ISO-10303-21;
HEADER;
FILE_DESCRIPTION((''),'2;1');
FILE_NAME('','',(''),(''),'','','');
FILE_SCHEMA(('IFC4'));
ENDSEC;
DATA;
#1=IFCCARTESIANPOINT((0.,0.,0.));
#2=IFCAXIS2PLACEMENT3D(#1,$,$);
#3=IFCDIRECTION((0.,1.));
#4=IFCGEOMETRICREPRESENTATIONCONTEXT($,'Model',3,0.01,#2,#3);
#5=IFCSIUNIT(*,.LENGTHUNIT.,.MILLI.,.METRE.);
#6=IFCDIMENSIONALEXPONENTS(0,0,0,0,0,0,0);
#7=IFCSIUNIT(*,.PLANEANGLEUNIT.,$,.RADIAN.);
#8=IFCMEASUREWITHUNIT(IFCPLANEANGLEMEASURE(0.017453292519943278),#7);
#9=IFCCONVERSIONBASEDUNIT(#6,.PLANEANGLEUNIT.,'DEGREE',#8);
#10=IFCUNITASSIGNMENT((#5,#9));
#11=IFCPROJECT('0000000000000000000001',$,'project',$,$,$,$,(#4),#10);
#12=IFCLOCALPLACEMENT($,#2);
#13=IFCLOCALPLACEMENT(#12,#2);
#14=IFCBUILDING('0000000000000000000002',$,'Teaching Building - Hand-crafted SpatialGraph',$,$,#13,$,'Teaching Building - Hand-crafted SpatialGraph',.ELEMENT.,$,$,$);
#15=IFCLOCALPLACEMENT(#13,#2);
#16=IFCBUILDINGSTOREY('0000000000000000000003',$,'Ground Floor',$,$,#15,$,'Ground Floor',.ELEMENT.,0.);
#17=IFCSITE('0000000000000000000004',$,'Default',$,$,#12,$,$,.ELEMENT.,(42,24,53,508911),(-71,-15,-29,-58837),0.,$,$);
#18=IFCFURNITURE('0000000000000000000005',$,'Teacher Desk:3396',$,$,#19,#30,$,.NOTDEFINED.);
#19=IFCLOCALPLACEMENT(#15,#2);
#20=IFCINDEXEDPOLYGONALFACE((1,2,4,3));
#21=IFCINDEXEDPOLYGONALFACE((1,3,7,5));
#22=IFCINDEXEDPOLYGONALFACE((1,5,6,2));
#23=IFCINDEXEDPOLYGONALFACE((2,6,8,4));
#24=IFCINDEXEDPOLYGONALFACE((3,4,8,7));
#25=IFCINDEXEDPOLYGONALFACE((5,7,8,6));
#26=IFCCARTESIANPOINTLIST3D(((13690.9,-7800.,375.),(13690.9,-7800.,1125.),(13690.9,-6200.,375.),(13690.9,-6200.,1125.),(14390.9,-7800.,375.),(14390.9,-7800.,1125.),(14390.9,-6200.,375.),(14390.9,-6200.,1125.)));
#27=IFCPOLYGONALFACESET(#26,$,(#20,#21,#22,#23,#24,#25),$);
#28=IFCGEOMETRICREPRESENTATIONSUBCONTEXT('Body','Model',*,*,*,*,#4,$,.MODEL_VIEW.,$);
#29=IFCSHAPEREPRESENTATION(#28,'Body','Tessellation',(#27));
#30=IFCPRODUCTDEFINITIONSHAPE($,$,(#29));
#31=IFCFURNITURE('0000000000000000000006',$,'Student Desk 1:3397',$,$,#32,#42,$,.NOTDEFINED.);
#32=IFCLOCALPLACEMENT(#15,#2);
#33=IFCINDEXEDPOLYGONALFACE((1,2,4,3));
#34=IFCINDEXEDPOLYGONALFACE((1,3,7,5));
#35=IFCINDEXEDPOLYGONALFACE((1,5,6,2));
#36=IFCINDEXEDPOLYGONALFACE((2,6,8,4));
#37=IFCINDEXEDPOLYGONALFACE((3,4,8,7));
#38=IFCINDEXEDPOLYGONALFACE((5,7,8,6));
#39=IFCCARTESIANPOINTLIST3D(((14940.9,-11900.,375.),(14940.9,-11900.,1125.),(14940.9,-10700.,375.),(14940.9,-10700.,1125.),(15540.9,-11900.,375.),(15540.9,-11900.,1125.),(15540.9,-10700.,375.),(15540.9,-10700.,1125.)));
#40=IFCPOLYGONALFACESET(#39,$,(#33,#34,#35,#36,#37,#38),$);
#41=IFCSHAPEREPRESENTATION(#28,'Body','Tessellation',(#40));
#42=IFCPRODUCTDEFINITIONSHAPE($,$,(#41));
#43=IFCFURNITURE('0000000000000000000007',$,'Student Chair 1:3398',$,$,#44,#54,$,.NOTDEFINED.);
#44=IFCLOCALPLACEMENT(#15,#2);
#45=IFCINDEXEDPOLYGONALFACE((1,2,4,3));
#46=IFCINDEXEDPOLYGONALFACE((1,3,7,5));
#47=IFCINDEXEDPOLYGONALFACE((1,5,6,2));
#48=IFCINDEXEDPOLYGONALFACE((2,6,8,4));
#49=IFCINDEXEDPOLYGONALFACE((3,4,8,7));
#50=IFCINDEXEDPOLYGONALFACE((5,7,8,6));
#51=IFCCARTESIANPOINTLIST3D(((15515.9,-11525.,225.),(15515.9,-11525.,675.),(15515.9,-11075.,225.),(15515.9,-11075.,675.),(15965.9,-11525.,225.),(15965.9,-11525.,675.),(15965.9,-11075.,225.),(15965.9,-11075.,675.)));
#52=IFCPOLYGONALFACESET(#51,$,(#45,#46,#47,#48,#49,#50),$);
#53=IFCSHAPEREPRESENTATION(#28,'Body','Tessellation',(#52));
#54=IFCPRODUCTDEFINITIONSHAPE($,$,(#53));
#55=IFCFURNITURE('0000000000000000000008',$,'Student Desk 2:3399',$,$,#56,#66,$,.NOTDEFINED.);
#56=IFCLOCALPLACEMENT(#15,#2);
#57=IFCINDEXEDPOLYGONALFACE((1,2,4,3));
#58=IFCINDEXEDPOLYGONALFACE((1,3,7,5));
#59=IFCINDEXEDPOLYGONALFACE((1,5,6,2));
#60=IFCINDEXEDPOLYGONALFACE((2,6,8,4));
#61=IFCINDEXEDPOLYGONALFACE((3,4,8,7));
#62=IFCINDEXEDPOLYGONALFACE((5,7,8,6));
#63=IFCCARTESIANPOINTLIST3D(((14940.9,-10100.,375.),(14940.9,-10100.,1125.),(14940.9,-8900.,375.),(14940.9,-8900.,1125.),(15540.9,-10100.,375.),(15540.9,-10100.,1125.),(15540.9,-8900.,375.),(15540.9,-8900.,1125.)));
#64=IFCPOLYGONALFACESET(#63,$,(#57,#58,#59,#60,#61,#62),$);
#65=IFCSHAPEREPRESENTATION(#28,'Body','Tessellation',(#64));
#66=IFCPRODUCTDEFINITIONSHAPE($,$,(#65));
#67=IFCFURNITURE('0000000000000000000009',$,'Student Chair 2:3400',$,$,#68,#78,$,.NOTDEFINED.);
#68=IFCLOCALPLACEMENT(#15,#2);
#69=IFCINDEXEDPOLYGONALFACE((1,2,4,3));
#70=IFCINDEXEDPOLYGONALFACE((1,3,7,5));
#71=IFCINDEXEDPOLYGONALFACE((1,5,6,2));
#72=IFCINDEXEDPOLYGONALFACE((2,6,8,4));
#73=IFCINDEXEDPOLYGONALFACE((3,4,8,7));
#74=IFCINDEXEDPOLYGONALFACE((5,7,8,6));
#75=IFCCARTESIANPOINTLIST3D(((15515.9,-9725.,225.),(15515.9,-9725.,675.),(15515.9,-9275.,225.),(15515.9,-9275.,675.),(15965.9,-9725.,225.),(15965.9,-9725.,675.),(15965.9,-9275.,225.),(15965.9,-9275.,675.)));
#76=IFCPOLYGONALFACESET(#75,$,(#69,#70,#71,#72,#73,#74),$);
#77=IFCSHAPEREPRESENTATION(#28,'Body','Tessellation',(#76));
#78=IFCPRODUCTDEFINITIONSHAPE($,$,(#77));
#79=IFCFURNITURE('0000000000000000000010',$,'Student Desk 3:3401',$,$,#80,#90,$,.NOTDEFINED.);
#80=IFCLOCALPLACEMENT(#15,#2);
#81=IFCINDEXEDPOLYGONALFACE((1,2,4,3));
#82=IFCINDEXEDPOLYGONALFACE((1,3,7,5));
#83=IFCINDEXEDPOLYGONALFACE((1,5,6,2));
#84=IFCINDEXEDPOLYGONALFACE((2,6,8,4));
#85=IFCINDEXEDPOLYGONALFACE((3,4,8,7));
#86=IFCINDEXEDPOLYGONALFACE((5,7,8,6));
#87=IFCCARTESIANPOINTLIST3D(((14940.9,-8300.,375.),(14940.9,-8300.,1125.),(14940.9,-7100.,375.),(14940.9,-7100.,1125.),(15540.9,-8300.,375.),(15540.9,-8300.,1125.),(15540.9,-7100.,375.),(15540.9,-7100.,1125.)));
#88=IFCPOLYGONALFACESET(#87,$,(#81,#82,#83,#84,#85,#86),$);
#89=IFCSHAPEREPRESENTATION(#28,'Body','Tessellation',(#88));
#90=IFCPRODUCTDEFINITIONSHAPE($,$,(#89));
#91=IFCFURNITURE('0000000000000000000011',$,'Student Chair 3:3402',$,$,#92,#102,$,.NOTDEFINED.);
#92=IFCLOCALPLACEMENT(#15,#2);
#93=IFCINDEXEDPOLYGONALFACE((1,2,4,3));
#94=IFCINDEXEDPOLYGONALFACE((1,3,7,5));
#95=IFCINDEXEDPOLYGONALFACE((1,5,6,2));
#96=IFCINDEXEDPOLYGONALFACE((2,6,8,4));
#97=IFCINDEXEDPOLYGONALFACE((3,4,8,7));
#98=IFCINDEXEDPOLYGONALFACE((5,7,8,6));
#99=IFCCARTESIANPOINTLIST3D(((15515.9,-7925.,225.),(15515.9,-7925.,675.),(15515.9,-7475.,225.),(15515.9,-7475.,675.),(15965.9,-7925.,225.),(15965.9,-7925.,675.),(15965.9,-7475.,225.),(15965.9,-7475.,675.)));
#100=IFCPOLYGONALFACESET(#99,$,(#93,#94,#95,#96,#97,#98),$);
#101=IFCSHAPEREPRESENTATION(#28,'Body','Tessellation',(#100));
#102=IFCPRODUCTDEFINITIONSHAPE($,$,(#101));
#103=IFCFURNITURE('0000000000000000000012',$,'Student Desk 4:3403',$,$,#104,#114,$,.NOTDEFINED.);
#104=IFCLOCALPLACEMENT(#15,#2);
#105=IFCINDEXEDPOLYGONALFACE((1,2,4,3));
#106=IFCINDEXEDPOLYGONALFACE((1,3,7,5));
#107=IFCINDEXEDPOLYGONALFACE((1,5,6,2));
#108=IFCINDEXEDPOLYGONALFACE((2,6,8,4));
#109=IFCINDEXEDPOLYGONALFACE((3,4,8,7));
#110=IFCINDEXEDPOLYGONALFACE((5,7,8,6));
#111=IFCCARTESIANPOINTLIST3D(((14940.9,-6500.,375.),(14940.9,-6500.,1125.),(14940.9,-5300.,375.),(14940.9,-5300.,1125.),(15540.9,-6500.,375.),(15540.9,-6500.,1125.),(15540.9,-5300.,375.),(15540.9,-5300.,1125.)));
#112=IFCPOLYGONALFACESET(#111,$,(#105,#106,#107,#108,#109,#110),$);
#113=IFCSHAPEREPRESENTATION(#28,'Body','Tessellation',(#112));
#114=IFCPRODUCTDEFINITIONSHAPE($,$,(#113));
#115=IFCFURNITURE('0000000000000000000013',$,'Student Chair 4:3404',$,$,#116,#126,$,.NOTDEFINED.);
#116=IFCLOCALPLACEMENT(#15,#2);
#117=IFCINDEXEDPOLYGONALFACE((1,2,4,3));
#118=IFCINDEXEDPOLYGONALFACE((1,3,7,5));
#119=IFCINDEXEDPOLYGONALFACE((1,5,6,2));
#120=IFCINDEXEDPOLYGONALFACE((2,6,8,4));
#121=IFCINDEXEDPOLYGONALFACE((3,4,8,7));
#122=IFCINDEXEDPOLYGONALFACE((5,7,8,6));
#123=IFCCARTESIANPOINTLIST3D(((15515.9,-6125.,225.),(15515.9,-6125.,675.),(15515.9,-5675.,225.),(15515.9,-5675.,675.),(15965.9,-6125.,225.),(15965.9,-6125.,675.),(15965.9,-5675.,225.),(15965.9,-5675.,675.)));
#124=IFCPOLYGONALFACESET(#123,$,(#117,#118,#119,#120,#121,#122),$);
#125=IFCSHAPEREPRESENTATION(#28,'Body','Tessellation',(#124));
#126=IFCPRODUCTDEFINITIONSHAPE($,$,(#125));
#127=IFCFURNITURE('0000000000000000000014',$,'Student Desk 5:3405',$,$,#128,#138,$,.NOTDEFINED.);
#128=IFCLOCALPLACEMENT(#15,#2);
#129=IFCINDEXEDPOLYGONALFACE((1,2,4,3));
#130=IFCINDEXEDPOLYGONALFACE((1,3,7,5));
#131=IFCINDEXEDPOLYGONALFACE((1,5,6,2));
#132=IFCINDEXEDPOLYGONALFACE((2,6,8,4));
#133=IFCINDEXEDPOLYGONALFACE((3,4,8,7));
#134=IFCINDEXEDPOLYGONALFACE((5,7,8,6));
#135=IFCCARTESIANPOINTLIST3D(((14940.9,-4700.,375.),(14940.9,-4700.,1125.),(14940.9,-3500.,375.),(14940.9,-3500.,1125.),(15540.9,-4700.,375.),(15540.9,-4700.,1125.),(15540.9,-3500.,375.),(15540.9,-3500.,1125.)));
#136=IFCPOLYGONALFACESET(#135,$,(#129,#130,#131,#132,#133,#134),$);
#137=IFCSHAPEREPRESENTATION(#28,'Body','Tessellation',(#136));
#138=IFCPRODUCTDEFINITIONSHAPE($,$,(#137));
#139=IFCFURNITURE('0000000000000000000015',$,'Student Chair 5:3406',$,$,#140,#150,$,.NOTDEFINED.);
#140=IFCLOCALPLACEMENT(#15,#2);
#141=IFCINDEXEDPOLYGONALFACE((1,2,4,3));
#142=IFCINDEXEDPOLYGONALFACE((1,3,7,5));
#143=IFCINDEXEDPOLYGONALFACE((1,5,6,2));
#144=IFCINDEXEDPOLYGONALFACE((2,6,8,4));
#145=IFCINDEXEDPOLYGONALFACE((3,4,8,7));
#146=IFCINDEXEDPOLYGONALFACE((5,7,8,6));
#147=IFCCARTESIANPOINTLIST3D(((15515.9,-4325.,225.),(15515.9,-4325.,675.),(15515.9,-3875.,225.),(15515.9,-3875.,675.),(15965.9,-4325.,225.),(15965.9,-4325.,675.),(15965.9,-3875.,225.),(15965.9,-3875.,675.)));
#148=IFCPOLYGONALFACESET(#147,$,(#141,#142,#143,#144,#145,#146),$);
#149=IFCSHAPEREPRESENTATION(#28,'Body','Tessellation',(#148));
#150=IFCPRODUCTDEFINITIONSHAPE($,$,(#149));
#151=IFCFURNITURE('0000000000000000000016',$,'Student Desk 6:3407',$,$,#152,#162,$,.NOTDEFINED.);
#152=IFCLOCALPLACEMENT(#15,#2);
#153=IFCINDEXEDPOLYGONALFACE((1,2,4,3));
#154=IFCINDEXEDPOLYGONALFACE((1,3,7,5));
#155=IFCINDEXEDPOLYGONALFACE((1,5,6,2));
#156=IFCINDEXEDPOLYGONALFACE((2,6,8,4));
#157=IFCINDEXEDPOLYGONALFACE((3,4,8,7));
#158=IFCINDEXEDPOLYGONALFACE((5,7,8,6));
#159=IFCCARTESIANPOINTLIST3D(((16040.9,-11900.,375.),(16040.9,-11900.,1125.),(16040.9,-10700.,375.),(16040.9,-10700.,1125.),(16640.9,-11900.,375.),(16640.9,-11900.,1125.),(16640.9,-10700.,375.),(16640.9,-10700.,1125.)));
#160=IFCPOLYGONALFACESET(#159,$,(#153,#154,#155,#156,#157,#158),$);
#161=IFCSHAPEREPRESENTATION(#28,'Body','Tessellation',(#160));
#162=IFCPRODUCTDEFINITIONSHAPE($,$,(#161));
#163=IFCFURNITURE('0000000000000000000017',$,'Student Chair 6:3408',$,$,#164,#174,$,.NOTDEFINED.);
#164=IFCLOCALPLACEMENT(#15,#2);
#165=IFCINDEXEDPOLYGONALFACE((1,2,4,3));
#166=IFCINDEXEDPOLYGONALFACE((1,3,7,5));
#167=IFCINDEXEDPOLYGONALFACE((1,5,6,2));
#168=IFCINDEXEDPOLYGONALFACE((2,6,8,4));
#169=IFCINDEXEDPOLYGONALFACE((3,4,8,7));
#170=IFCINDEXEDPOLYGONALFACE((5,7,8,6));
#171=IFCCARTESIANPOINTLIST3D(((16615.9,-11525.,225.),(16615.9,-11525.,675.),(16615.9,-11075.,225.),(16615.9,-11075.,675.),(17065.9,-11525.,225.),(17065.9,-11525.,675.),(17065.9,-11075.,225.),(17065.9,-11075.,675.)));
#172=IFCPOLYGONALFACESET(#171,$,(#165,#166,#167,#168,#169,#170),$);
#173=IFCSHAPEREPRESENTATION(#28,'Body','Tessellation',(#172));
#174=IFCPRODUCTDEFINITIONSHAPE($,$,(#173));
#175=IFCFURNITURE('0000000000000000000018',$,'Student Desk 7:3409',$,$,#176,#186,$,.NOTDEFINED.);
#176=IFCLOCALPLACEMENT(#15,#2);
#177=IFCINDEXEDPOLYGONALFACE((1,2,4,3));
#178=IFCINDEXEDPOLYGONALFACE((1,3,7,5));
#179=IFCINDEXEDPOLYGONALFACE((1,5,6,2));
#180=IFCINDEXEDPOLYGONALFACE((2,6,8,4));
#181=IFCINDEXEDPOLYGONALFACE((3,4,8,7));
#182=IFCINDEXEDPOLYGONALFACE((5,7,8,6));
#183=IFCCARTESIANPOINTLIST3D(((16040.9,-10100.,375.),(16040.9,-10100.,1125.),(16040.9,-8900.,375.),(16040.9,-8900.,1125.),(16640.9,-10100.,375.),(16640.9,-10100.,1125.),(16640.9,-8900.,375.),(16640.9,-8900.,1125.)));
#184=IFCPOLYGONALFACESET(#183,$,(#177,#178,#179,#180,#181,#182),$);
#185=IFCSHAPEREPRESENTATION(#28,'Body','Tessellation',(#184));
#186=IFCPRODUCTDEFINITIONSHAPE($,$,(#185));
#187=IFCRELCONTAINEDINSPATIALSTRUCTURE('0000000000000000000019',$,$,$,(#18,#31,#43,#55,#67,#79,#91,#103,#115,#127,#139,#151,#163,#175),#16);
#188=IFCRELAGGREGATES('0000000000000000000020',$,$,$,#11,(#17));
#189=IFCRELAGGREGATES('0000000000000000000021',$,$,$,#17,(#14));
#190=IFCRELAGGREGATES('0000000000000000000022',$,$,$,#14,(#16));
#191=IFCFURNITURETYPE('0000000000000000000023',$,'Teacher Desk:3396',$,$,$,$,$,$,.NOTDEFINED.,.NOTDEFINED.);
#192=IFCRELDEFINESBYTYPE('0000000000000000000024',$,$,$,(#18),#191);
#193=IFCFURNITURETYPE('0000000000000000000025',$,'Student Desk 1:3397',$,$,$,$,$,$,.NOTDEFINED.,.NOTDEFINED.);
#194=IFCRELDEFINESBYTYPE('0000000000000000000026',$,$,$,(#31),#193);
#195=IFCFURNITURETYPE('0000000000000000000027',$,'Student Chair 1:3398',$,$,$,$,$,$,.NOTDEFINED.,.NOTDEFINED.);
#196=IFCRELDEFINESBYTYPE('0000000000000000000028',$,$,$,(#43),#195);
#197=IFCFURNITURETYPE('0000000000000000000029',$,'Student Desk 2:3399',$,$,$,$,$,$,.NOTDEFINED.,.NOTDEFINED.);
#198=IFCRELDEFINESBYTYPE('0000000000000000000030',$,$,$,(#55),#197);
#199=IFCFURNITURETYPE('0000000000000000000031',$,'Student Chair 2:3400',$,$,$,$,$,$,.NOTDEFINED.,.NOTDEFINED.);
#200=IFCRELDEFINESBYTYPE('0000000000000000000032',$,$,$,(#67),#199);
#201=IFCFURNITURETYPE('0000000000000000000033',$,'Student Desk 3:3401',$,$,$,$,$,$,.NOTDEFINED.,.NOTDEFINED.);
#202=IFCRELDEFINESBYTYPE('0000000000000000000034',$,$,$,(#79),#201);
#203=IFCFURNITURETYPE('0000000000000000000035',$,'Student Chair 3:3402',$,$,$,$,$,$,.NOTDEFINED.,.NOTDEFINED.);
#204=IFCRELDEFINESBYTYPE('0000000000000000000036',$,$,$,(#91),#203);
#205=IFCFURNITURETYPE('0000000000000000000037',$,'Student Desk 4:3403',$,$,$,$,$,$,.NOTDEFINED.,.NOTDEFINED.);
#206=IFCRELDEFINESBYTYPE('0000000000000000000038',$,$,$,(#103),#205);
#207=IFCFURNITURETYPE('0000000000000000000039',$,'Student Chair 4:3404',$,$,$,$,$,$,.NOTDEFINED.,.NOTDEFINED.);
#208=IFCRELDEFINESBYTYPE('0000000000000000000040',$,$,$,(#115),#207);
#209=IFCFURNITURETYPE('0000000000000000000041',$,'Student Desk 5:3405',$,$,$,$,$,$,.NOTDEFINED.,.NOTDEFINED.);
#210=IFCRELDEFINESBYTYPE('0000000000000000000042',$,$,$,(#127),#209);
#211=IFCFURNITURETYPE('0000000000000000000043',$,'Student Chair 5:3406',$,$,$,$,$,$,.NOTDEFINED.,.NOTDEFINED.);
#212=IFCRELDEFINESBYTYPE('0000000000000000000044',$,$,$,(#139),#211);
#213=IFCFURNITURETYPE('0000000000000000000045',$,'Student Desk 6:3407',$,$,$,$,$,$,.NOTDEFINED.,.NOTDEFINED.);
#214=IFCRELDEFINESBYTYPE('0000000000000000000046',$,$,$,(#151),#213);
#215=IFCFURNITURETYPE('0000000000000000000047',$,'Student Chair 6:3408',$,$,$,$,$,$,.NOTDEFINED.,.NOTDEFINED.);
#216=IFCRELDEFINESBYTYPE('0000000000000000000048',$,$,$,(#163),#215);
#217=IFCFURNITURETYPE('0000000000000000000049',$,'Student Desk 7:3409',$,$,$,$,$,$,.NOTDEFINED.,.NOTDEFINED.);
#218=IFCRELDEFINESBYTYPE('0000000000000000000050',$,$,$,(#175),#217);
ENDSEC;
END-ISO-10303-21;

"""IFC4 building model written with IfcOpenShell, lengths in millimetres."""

from ifc_helpers import new_model, entity, si_unit, converted_unit, direction, frame, frame_2d, origin, origin_2d_with_axis, place, context, subcontext, project, spatial, rectangle, extrude, type_object, element, save


model = new_model("IFC4")

# Units and contexts
model_context = context("Model", 3, precision=0.01, world=origin(), true_north=direction((0.0, 1.0)))
body_context = subcontext(model_context, "Body", "Model", "MODEL_VIEW")
ifc_project = project(units=[si_unit("LENGTHUNIT", "METRE", prefix="MILLI"), converted_unit("PLANEANGLEUNIT", "DEGREE", entity("IfcPlaneAngleMeasure", 0.017453292519943278), si_unit("PLANEANGLEUNIT", "RADIAN"), dimensions=[0, 0, 0, 0, 0, 0, 0])], contexts=[model_context])

# Site, building, storey
site_placement = place(None, origin())
site = spatial("IfcSite", under=ifc_project, at=site_placement, Name="Default", CompositionType="ELEMENT", RefLatitude=(42, 24, 53, 508911), RefLongitude=(-71, -15, -29, -58837), RefElevation=0.0)
building_placement = place(site_placement, origin())
building = spatial("IfcBuilding", under=site, at=building_placement, Name="Teaching Building - Hand-crafted SpatialGraph", LongName="Teaching Building - Hand-crafted SpatialGraph", CompositionType="ELEMENT")
storey_placement = place(building_placement, origin())
storey = spatial("IfcBuildingStorey", under=building, at=storey_placement, Name="Ground Floor", LongName="Ground Floor", CompositionType="ELEMENT", Elevation=0.0)

# Furniture
furniture_type_1 = type_object("IfcFurnitureType", Name="Teacher Desk:3396", PredefinedType="NOTDEFINED")
furniture_1_placement = place(storey_placement, origin())
element("IfcFurniture", 1, at=furniture_1_placement, inside=storey, type_object=furniture_type_1, Name="Teacher Desk:3396", PredefinedType="NOTDEFINED", context=body_context, shape_type="SweptSolid", body=[
    extrude(rectangle(XDim=1600.0, YDim=700.0, at=origin_2d_with_axis()), frame((14040.9, -7000.0, 375.0), z_axis=(0.0, 0.0, 1.0), x_axis=(0.0, 1.0, 0.0)), (0.0, 0.0, 1.0), 750.0),
])
furniture_type_2 = type_object("IfcFurnitureType", Name="Student Desk 1:3397", PredefinedType="NOTDEFINED")
furniture_2_placement = place(storey_placement, origin())
element("IfcFurniture", 2, at=furniture_2_placement, inside=storey, type_object=furniture_type_2, Name="Student Desk 1:3397", PredefinedType="NOTDEFINED", context=body_context, shape_type="SweptSolid", body=[
    extrude(rectangle(XDim=1200.0, YDim=600.0, at=origin_2d_with_axis()), frame((15240.9, -11300.0, 375.0), z_axis=(0.0, 0.0, 1.0), x_axis=(0.0, 1.0, 0.0)), (0.0, 0.0, 1.0), 750.0),
])
furniture_type_3 = type_object("IfcFurnitureType", Name="Student Chair 1:3398", PredefinedType="NOTDEFINED")
furniture_3_placement = place(storey_placement, origin())
element("IfcFurniture", 3, at=furniture_3_placement, inside=storey, type_object=furniture_type_3, Name="Student Chair 1:3398", PredefinedType="NOTDEFINED", context=body_context, shape_type="SweptSolid", body=[
    extrude(rectangle(XDim=450.0, YDim=450.0, at=origin_2d_with_axis()), frame((15740.9, -11300.0, 225.0)), (0.0, 0.0, 1.0), 450.0),
])
furniture_type_4 = type_object("IfcFurnitureType", Name="Student Desk 2:3399", PredefinedType="NOTDEFINED")
furniture_4_placement = place(storey_placement, origin())
element("IfcFurniture", 4, at=furniture_4_placement, inside=storey, type_object=furniture_type_4, Name="Student Desk 2:3399", PredefinedType="NOTDEFINED", context=body_context, shape_type="SweptSolid", body=[
    extrude(rectangle(XDim=1200.0, YDim=600.0, at=origin_2d_with_axis()), frame((15240.9, -9500.0, 375.0), z_axis=(0.0, 0.0, 1.0), x_axis=(0.0, 1.0, 0.0)), (0.0, 0.0, 1.0), 750.0),
])
furniture_type_5 = type_object("IfcFurnitureType", Name="Student Chair 2:3400", PredefinedType="NOTDEFINED")
furniture_5_placement = place(storey_placement, origin())
element("IfcFurniture", 5, at=furniture_5_placement, inside=storey, type_object=furniture_type_5, Name="Student Chair 2:3400", PredefinedType="NOTDEFINED", context=body_context, shape_type="SweptSolid", body=[
    extrude(rectangle(XDim=450.0, YDim=450.0, at=origin_2d_with_axis()), frame((15740.9, -9500.0, 225.0)), (0.0, 0.0, 1.0), 450.0),
])
furniture_type_6 = type_object("IfcFurnitureType", Name="Student Desk 3:3401", PredefinedType="NOTDEFINED")
furniture_6_placement = place(storey_placement, origin())
element("IfcFurniture", 6, at=furniture_6_placement, inside=storey, type_object=furniture_type_6, Name="Student Desk 3:3401", PredefinedType="NOTDEFINED", context=body_context, shape_type="SweptSolid", body=[
    extrude(rectangle(XDim=1200.0, YDim=600.0, at=origin_2d_with_axis()), frame((15240.9, -7700.0, 375.0), z_axis=(0.0, 0.0, 1.0), x_axis=(0.0, 1.0, 0.0)), (0.0, 0.0, 1.0), 750.0),
])
furniture_type_7 = type_object("IfcFurnitureType", Name="Student Chair 3:3402", PredefinedType="NOTDEFINED")
furniture_7_placement = place(storey_placement, origin())
element("IfcFurniture", 7, at=furniture_7_placement, inside=storey, type_object=furniture_type_7, Name="Student Chair 3:3402", PredefinedType="NOTDEFINED", context=body_context, shape_type="SweptSolid", body=[
    extrude(rectangle(XDim=450.0, YDim=450.0, at=frame_2d((0.0, 0.0), x_axis=(1.0, 0.0))), frame((15740.9, -7700.0, 225.0)), (0.0, 0.0, 1.0), 450.0),
])
furniture_type_8 = type_object("IfcFurnitureType", Name="Student Desk 4:3403", PredefinedType="NOTDEFINED")
furniture_8_placement = place(storey_placement, origin())
element("IfcFurniture", 8, at=furniture_8_placement, inside=storey, type_object=furniture_type_8, Name="Student Desk 4:3403", PredefinedType="NOTDEFINED", context=body_context, shape_type="SweptSolid", body=[
    extrude(rectangle(XDim=1200.0, YDim=600.0, at=origin_2d_with_axis()), frame((15240.9, -5900.0, 375.0), z_axis=(0.0, 0.0, 1.0), x_axis=(0.0, 1.0, 0.0)), (0.0, 0.0, 1.0), 750.0),
])
furniture_type_9 = type_object("IfcFurnitureType", Name="Student Chair 4:3404", PredefinedType="NOTDEFINED")
furniture_9_placement = place(storey_placement, origin())
element("IfcFurniture", 9, at=furniture_9_placement, inside=storey, type_object=furniture_type_9, Name="Student Chair 4:3404", PredefinedType="NOTDEFINED", context=body_context, shape_type="SweptSolid", body=[
    extrude(rectangle(XDim=450.0, YDim=450.0, at=origin_2d_with_axis()), frame((15740.9, -5900.0, 225.0)), (0.0, 0.0, 1.0), 450.0),
])
furniture_type_10 = type_object("IfcFurnitureType", Name="Student Desk 5:3405", PredefinedType="NOTDEFINED")
furniture_10_placement = place(storey_placement, origin())
element("IfcFurniture", 10, at=furniture_10_placement, inside=storey, type_object=furniture_type_10, Name="Student Desk 5:3405", PredefinedType="NOTDEFINED", context=body_context, shape_type="SweptSolid", body=[
    extrude(rectangle(XDim=1200.0, YDim=600.0, at=origin_2d_with_axis()), frame((15240.9, -4100.0, 375.0), z_axis=(0.0, 0.0, 1.0), x_axis=(0.0, 1.0, 0.0)), (0.0, 0.0, 1.0), 750.0),
])
furniture_type_11 = type_object("IfcFurnitureType", Name="Student Chair 5:3406", PredefinedType="NOTDEFINED")
furniture_11_placement = place(storey_placement, origin())
element("IfcFurniture", 11, at=furniture_11_placement, inside=storey, type_object=furniture_type_11, Name="Student Chair 5:3406", PredefinedType="NOTDEFINED", context=body_context, shape_type="SweptSolid", body=[
    extrude(rectangle(XDim=450.0, YDim=450.0, at=origin_2d_with_axis()), frame((15740.9, -4100.0, 225.0)), (0.0, 0.0, 1.0), 450.0),
])
furniture_type_12 = type_object("IfcFurnitureType", Name="Student Desk 6:3407", PredefinedType="NOTDEFINED")
furniture_12_placement = place(storey_placement, origin())
element("IfcFurniture", 12, at=furniture_12_placement, inside=storey, type_object=furniture_type_12, Name="Student Desk 6:3407", PredefinedType="NOTDEFINED", context=body_context, shape_type="SweptSolid", body=[
    extrude(rectangle(XDim=1200.0, YDim=600.0, at=origin_2d_with_axis()), frame((16340.9, -11300.0, 375.0), z_axis=(0.0, 0.0, 1.0), x_axis=(0.0, 1.0, 0.0)), (0.0, 0.0, 1.0), 750.0),
])
furniture_type_13 = type_object("IfcFurnitureType", Name="Student Chair 6:3408", PredefinedType="NOTDEFINED")
furniture_13_placement = place(storey_placement, origin())
element("IfcFurniture", 13, at=furniture_13_placement, inside=storey, type_object=furniture_type_13, Name="Student Chair 6:3408", PredefinedType="NOTDEFINED", context=body_context, shape_type="SweptSolid", body=[
    extrude(rectangle(XDim=450.0, YDim=450.0, at=origin_2d_with_axis()), frame((16840.9, -11300.0, 225.0)), (0.0, 0.0, 1.0), 450.0),
])
furniture_type_14 = type_object("IfcFurnitureType", Name="Student Desk 7:3409", PredefinedType="NOTDEFINED")
furniture_14_placement = place(storey_placement, origin())
element("IfcFurniture", 14, at=furniture_14_placement, inside=storey, type_object=furniture_type_14, Name="Student Desk 7:3409", PredefinedType="NOTDEFINED", context=body_context, shape_type="SweptSolid", body=[
    extrude(rectangle(XDim=1200.0, YDim=600.0, at=origin_2d_with_axis()), frame((16340.9, -9500.0, 375.0), z_axis=(0.0, 0.0, 1.0), x_axis=(0.0, 1.0, 0.0)), (0.0, 0.0, 1.0), 750.0),
])

save(model, "model.ifc")
